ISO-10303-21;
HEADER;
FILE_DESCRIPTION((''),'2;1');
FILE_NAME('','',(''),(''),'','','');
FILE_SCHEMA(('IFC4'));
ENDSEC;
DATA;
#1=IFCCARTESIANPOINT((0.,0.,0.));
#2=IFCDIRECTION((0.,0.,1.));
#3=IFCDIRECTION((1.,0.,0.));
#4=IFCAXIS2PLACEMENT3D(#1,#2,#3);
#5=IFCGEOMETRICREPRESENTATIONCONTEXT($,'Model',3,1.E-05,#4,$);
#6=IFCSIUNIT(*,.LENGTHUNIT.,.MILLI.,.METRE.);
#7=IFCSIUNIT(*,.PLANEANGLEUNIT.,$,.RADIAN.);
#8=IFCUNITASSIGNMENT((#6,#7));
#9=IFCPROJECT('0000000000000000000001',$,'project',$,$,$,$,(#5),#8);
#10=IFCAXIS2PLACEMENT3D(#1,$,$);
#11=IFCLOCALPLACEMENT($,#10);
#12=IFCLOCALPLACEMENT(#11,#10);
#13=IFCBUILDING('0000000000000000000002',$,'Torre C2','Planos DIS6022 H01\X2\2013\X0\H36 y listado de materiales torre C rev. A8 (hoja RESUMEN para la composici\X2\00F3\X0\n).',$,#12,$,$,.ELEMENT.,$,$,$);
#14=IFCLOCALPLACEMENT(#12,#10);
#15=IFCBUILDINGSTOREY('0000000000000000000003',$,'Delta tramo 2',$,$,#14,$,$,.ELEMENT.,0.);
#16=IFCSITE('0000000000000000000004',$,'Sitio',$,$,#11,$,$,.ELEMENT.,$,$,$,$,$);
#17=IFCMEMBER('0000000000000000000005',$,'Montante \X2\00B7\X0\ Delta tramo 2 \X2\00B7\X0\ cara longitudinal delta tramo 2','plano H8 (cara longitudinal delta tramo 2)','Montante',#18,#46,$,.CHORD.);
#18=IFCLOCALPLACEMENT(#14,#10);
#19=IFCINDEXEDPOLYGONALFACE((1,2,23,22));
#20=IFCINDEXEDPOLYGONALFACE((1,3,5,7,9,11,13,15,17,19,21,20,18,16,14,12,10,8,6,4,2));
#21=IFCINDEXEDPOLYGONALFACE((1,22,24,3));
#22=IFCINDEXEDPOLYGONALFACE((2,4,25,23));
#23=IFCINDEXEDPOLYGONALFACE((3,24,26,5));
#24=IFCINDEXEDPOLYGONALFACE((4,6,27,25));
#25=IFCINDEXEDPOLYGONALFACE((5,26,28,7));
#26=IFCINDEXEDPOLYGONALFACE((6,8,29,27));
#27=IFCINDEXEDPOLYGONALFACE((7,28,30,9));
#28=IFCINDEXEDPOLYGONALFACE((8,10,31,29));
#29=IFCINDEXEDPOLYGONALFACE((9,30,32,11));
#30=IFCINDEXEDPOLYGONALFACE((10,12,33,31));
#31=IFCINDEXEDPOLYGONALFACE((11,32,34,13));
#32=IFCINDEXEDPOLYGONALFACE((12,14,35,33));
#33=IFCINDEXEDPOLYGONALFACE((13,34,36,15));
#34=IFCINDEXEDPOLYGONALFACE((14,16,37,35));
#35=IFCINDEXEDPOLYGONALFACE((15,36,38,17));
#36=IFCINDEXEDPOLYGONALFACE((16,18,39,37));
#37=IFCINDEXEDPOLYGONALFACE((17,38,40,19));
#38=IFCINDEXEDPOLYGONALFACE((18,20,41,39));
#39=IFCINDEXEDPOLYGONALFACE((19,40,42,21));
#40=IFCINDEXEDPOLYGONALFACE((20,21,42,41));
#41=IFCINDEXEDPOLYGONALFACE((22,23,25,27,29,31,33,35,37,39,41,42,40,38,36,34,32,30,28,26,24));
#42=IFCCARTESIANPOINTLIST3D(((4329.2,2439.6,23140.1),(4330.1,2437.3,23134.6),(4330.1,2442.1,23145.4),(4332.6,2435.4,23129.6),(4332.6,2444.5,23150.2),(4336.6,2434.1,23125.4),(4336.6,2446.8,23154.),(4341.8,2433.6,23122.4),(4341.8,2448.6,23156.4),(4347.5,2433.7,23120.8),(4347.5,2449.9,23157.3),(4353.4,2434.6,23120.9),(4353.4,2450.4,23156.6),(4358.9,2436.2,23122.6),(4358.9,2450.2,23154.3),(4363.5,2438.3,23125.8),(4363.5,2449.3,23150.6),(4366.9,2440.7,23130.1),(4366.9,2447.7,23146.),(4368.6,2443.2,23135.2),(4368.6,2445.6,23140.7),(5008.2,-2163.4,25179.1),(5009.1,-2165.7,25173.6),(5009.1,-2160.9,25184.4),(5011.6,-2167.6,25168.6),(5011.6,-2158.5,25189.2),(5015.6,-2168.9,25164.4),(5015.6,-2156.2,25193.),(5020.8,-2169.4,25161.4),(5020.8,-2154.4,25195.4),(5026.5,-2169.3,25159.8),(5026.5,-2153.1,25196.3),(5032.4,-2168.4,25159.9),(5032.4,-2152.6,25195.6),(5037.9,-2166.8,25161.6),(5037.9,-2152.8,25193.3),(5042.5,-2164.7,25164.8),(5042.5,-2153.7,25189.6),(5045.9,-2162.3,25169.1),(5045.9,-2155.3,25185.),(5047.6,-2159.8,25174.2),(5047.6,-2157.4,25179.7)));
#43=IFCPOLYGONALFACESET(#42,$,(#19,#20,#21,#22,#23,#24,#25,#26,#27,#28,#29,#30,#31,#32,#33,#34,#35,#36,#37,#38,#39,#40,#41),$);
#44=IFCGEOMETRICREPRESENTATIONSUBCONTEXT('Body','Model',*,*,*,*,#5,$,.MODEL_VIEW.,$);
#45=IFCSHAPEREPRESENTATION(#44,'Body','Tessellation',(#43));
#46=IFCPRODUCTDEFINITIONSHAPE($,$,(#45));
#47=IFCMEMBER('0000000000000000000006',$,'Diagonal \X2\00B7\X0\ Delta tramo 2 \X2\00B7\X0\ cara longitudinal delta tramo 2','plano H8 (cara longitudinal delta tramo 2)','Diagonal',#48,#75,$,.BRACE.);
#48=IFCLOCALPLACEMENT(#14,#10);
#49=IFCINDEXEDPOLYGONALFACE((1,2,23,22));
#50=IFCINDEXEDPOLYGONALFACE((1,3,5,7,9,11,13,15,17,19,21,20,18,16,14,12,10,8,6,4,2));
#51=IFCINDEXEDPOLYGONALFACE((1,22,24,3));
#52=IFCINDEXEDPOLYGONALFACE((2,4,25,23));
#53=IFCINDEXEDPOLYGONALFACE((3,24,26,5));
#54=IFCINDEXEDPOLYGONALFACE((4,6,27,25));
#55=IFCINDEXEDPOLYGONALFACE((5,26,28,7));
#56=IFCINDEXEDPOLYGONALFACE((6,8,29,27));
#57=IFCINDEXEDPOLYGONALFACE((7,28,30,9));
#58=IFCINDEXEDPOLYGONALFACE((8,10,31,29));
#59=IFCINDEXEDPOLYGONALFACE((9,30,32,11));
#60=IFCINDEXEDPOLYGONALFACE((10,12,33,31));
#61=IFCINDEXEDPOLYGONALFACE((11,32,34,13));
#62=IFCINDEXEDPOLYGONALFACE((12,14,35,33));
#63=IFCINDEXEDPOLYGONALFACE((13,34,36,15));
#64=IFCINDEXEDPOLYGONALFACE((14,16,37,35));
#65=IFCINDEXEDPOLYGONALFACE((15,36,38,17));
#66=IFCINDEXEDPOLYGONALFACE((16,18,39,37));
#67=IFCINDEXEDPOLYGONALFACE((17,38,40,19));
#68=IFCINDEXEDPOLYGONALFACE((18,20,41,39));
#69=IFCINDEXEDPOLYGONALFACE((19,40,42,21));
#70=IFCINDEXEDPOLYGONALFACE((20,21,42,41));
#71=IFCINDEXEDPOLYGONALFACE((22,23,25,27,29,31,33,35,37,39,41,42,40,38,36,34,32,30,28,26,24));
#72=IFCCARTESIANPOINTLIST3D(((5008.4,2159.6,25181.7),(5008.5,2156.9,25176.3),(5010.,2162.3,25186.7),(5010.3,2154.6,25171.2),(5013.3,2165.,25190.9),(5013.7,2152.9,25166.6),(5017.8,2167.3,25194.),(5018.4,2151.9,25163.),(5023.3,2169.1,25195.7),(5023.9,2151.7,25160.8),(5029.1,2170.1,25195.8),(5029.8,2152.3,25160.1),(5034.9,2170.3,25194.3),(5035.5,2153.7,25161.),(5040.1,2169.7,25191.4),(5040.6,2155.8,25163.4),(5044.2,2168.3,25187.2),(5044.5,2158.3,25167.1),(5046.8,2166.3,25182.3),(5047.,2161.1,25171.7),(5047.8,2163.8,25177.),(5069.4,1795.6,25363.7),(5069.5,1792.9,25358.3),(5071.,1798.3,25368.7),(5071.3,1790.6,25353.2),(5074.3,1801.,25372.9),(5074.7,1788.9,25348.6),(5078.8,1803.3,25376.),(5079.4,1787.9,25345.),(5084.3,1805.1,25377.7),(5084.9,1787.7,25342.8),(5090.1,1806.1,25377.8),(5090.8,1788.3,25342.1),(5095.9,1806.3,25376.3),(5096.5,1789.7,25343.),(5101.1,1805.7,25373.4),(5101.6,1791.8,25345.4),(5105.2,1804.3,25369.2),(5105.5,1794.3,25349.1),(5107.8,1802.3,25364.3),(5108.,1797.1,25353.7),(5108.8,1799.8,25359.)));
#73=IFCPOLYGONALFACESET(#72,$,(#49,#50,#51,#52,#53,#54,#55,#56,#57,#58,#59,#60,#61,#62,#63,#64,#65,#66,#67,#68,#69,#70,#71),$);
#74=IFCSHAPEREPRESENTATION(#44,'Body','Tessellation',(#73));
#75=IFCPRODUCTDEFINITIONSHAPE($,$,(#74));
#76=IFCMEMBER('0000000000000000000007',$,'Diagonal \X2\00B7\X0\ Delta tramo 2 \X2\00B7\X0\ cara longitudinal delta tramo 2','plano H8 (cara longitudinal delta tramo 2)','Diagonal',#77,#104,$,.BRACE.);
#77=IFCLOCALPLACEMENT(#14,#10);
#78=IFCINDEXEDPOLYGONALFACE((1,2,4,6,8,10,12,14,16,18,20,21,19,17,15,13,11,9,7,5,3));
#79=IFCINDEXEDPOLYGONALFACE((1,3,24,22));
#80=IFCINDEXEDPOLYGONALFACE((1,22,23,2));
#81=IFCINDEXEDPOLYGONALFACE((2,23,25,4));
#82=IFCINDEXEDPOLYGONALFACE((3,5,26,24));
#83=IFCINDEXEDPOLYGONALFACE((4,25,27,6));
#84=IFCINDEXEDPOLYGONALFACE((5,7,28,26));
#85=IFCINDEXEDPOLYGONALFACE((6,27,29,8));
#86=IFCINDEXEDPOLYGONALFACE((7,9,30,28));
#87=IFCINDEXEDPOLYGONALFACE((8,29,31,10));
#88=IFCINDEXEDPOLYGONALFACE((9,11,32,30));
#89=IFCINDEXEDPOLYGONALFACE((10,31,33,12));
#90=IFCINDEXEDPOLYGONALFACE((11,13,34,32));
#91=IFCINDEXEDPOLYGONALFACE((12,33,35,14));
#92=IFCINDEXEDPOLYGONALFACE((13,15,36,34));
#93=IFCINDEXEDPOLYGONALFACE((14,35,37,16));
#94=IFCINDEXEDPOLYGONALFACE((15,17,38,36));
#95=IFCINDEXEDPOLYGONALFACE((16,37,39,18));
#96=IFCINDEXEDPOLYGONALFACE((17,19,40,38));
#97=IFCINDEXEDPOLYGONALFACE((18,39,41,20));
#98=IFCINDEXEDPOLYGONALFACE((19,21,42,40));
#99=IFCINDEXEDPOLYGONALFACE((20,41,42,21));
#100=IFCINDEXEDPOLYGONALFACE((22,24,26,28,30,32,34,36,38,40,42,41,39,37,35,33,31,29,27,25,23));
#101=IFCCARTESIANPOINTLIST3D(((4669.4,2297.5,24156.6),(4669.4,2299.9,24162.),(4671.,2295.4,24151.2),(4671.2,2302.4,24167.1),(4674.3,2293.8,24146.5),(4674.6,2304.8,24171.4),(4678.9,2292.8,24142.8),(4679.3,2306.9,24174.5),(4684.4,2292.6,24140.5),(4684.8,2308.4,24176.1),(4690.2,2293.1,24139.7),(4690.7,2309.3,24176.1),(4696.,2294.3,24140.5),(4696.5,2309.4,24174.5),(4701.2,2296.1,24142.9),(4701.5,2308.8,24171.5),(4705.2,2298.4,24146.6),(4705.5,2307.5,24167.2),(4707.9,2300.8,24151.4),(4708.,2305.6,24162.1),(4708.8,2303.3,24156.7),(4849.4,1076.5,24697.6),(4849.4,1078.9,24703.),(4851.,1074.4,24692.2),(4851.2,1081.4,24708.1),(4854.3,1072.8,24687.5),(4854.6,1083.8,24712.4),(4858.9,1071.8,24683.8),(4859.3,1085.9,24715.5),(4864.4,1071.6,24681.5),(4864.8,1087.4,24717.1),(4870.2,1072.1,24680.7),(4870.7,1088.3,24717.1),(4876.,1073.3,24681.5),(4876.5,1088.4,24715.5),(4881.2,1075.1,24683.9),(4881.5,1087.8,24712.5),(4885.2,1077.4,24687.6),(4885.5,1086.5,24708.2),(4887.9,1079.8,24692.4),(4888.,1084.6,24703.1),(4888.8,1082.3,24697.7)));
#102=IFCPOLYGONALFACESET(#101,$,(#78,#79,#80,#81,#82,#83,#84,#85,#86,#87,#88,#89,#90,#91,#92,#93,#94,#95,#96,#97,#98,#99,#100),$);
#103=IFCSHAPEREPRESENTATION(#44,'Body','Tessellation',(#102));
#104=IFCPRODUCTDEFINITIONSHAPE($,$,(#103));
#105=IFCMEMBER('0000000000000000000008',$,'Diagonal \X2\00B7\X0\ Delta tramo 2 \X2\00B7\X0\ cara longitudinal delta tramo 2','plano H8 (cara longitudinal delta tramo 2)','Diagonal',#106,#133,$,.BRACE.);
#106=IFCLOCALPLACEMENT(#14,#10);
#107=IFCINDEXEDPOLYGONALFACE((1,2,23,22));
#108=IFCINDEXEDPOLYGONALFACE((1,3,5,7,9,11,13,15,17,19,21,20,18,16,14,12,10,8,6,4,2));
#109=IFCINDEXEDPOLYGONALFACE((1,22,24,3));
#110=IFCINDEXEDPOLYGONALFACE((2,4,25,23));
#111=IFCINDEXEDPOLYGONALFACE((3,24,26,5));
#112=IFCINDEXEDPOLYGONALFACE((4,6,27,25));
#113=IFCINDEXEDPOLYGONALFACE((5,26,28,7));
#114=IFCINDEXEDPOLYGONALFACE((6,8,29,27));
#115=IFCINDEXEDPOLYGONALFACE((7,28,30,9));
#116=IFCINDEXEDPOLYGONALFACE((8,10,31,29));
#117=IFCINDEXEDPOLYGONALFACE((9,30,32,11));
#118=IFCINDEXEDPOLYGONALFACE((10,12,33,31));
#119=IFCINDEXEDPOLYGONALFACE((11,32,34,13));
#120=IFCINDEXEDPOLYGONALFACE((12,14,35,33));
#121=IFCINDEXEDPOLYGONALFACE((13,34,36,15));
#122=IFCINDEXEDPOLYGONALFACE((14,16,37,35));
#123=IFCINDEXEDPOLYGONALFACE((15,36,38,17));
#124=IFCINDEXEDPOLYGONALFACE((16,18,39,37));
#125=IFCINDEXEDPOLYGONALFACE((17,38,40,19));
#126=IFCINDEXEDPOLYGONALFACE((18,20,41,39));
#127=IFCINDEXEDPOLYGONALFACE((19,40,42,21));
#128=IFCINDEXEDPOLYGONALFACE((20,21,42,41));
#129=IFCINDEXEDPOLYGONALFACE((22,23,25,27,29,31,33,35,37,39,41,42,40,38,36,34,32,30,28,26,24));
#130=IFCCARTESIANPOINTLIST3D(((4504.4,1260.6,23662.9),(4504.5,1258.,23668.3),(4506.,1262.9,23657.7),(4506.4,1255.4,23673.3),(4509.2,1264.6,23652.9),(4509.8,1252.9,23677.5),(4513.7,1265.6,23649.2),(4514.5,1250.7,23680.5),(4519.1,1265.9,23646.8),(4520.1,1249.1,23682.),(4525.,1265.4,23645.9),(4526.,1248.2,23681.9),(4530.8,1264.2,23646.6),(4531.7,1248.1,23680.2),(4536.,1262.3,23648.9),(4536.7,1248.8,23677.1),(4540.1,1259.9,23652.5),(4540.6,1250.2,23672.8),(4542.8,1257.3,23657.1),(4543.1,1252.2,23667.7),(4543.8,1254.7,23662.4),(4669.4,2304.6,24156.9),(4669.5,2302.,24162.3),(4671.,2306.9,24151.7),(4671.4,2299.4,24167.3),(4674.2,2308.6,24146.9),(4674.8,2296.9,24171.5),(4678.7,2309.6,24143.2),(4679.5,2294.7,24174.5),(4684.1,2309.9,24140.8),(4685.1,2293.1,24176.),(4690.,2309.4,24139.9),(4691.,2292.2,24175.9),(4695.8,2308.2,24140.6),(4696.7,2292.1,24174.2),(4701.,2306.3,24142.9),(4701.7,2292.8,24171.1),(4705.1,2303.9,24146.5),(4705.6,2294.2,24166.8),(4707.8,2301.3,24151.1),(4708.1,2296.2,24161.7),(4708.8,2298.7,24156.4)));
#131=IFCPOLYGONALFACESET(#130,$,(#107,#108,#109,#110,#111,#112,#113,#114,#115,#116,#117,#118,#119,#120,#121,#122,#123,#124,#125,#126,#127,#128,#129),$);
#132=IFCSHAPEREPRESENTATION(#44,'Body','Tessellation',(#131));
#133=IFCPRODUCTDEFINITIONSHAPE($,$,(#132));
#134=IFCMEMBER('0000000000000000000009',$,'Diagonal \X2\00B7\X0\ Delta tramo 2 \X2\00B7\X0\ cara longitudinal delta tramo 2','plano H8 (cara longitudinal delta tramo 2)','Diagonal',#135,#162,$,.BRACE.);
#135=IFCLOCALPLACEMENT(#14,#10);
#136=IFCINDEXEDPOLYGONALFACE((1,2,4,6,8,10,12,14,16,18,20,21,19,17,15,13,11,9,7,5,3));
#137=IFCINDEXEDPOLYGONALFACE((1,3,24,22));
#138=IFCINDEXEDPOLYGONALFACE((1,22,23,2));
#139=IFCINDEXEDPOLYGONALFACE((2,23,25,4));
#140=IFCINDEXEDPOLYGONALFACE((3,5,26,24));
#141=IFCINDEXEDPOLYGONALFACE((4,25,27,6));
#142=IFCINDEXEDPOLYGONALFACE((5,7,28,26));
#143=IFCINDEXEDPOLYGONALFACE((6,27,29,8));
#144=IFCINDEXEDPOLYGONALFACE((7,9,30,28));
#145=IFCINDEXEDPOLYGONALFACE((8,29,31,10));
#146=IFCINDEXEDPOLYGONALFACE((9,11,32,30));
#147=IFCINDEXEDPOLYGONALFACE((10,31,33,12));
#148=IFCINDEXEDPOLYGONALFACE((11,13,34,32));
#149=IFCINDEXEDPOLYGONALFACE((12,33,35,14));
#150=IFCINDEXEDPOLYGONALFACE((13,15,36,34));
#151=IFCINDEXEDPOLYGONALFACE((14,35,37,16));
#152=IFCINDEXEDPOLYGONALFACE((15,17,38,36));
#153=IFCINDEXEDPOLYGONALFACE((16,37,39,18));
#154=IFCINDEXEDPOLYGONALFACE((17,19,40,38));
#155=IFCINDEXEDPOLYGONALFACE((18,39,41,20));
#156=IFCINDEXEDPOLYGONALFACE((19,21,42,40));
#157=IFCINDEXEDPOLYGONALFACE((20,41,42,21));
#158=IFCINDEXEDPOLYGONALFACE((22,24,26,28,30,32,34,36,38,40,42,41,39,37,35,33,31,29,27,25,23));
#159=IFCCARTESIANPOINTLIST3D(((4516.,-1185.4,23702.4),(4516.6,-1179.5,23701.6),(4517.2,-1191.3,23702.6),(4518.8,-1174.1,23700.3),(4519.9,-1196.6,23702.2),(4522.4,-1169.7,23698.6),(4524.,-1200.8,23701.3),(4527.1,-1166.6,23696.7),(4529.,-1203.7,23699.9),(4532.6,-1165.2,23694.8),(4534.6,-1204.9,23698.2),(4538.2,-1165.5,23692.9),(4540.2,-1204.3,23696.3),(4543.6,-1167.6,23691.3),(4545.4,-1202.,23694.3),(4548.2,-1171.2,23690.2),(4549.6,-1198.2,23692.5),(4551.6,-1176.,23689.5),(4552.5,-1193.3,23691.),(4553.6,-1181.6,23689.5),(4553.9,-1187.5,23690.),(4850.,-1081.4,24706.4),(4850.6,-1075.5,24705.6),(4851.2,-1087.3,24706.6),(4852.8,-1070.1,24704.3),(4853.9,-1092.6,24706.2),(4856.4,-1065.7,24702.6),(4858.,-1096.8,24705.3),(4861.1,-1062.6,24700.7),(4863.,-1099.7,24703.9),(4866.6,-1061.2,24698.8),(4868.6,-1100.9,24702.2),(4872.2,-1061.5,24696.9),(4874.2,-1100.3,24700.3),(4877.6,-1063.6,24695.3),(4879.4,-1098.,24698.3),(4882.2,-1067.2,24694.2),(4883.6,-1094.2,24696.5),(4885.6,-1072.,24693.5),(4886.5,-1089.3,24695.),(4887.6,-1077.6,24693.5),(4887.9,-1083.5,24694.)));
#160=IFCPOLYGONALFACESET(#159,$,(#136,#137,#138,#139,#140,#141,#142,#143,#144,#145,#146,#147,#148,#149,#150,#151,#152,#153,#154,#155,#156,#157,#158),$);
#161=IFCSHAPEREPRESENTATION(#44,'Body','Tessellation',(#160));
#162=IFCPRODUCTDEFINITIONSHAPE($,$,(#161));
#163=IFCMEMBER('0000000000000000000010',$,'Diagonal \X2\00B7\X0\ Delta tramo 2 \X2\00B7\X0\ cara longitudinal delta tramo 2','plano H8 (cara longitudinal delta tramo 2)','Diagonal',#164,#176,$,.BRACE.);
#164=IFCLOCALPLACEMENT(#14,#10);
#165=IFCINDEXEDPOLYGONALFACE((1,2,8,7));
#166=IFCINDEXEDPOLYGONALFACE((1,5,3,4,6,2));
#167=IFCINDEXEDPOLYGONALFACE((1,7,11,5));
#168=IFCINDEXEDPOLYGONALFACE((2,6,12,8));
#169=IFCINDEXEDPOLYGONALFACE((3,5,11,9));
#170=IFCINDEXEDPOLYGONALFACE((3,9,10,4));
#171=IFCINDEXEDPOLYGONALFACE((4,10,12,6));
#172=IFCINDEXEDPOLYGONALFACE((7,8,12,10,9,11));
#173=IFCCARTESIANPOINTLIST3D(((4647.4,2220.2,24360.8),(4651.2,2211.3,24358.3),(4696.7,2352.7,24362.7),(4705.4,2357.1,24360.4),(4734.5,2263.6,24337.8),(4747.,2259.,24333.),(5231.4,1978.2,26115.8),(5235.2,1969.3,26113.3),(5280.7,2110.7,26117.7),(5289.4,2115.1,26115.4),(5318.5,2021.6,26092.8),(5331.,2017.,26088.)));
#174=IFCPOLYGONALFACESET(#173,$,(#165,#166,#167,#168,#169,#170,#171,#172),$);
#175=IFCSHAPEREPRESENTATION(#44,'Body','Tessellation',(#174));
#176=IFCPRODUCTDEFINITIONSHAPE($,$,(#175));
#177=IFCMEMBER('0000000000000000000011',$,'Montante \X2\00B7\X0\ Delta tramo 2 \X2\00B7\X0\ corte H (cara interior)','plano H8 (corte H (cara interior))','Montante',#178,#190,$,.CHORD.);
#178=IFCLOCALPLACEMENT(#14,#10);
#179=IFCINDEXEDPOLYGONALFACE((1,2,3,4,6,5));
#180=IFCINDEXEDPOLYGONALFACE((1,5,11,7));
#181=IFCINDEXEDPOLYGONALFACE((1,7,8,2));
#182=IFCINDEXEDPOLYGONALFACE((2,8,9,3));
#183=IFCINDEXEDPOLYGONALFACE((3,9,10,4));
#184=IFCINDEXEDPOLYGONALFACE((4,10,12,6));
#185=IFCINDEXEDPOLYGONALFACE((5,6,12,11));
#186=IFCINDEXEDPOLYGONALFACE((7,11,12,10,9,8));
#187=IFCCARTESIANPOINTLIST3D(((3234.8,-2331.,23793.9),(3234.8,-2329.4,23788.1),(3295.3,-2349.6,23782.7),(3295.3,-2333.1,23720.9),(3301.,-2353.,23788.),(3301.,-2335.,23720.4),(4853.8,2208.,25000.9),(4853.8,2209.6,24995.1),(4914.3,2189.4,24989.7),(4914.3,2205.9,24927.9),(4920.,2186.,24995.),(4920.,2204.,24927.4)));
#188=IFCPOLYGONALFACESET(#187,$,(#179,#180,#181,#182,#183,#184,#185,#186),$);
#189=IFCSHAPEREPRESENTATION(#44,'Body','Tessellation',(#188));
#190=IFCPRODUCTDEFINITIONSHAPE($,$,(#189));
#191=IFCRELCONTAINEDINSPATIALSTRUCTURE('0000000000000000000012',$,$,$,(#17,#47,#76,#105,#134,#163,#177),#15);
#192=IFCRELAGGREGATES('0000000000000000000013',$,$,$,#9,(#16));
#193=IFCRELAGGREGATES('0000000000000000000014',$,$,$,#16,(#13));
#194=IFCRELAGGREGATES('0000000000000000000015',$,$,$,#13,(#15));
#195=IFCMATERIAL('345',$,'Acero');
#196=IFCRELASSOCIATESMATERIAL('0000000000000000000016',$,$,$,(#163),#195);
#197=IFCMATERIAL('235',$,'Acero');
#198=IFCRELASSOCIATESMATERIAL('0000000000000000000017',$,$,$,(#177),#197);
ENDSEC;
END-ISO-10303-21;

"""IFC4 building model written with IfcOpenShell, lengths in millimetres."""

from ifc_helpers import new_model, si_unit, frame, frame_2d, origin, origin_with_axes, place, context, subcontext, project, spatial, circle, l_section, extrude, material, element, save


model = new_model("IFC4")

# Units and contexts
model_context = context("Model", 3, precision=1e-05, world=origin_with_axes())
body_context = subcontext(model_context, "Body", "Model", "MODEL_VIEW")
ifc_project = project(units=[si_unit("LENGTHUNIT", "METRE", prefix="MILLI"), si_unit("PLANEANGLEUNIT", "RADIAN")], contexts=[model_context])

# Site, building, storey
site_placement = place(None, origin())
site = spatial("IfcSite", under=ifc_project, at=site_placement, Name="Sitio", CompositionType="ELEMENT")
building_placement = place(site_placement, origin())
building = spatial("IfcBuilding", under=site, at=building_placement, Name="Torre C2", Description="Planos DIS6022 H01–H36 y listado de materiales torre C rev. A8 (hoja RESUMEN para la composición).", CompositionType="ELEMENT")
storey_placement = place(building_placement, origin())
storey = spatial("IfcBuildingStorey", under=building, at=storey_placement, Name="Delta tramo 2", CompositionType="ELEMENT", Elevation=0.0)

# Members
ifc_material_1 = material(Name="345", Category="Acero")
member_1_placement = place(storey_placement, frame((4349.0, 2442.0, 23139.0), z_axis=(0.133662, -0.906106, 0.40138), x_axis=(-0.991027, -0.122209, 0.054135)))
element("IfcMember", 1, at=member_1_placement, inside=storey, Name="Montante · Delta tramo 2 · cara longitudinal delta tramo 2", Description="plano H8 (cara longitudinal delta tramo 2)", ObjectType="Montante", PredefinedType="CHORD", context=body_context, shape_type="SweptSolid", body=[
    extrude(circle(Radius=20.0), None, (0.0, 0.0, 1.0), 5080.0),
])
member_2_placement = place(storey_placement, frame((5028.0, 2161.0, 25178.0), z_axis=(0.148234, -0.884546, 0.442273), x_axis=(-0.975269, -0.204886, -0.082896)))
element("IfcMember", 2, at=member_2_placement, inside=storey, Name="Diagonal · Delta tramo 2 · cara longitudinal delta tramo 2", Description="plano H8 (cara longitudinal delta tramo 2)", ObjectType="Diagonal", PredefinedType="BRACE", context=body_context, shape_type="SweptSolid", body=[
    extrude(circle(Radius=20.0), None, (0.0, 0.0, 1.0), 411.5),
])
member_3_placement = place(storey_placement, frame((4689.0, 2301.0, 24158.0), z_axis=(0.133575, -0.906081, 0.401466), x_axis=(-0.981661, -0.176564, -0.071878)))
element("IfcMember", 3, at=member_3_placement, inside=storey, Name="Diagonal · Delta tramo 2 · cara longitudinal delta tramo 2", Description="plano H8 (cara longitudinal delta tramo 2)", ObjectType="Diagonal", PredefinedType="BRACE", context=body_context, shape_type="SweptSolid", body=[
    extrude(circle(Radius=20.0), None, (0.0, 0.0, 1.0), 1347.6),
])
member_4_placement = place(storey_placement, frame((4524.0, 1257.0, 23664.0), z_axis=(0.141424, 0.894829, 0.423415), x_axis=(-0.975028, 0.051927, 0.215926)))
element("IfcMember", 4, at=member_4_placement, inside=storey, Name="Diagonal · Delta tramo 2 · cara longitudinal delta tramo 2", Description="plano H8 (cara longitudinal delta tramo 2)", ObjectType="Diagonal", PredefinedType="BRACE", context=body_context, shape_type="SweptSolid", body=[
    extrude(circle(Radius=20.0), None, (0.0, 0.0, 1.0), 1166.7),
])
member_5_placement = place(storey_placement, frame((4869.0, -1081.0, 24700.0), z_axis=(-0.314147, -0.097818, -0.944322), x_axis=(-0.920941, 0.273009, 0.278089)))
element("IfcMember", 5, at=member_5_placement, inside=storey, Name="Diagonal · Delta tramo 2 · cara longitudinal delta tramo 2", Description="plano H8 (cara longitudinal delta tramo 2)", ObjectType="Diagonal", PredefinedType="BRACE", context=body_context, shape_type="SweptSolid", body=[
    extrude(circle(Radius=20.0), None, (0.0, 0.0, 1.0), 1063.2),
])
member_6_placement = place(storey_placement, frame((5331.0, 2017.0, 26088.0), z_axis=(-0.313073, 0.129732, -0.940827), x_axis=(-0.871133, -0.433819, 0.230061)))
element("IfcMember", 6, at=member_6_placement, inside=storey, material=ifc_material_1, Name="Diagonal · Delta tramo 2 · cara longitudinal delta tramo 2", Description="plano H8 (cara longitudinal delta tramo 2)", ObjectType="Diagonal", PredefinedType="BRACE", context=body_context, shape_type="SweptSolid", body=[
    extrude(l_section(Depth=110.0, Width=110.0, Thickness=10.0, at=frame_2d((55.0, 55.0))), None, (0.0, 0.0, 1.0), 1865.4),
])
ifc_material_2 = material(Name="235", Category="Acero")
member_7_placement = place(storey_placement, frame((4920.0, 2186.0, 24995.0), z_axis=(-0.325889, -0.913656, -0.242957), x_axis=(-0.945408, 0.314944, 0.083749)))
element("IfcMember", 7, at=member_7_placement, inside=storey, material=ifc_material_2, Name="Montante · Delta tramo 2 · corte H (cara interior)", Description="plano H8 (corte H (cara interior))", ObjectType="Montante", PredefinedType="CHORD", context=body_context, shape_type="SweptSolid", body=[
    extrude(l_section(Depth=70.0, Width=70.0, Thickness=6.0, at=frame_2d((35.0, 35.0))), None, (0.0, 0.0, 1.0), 4968.0),
])

save(model, "model.ifc")
